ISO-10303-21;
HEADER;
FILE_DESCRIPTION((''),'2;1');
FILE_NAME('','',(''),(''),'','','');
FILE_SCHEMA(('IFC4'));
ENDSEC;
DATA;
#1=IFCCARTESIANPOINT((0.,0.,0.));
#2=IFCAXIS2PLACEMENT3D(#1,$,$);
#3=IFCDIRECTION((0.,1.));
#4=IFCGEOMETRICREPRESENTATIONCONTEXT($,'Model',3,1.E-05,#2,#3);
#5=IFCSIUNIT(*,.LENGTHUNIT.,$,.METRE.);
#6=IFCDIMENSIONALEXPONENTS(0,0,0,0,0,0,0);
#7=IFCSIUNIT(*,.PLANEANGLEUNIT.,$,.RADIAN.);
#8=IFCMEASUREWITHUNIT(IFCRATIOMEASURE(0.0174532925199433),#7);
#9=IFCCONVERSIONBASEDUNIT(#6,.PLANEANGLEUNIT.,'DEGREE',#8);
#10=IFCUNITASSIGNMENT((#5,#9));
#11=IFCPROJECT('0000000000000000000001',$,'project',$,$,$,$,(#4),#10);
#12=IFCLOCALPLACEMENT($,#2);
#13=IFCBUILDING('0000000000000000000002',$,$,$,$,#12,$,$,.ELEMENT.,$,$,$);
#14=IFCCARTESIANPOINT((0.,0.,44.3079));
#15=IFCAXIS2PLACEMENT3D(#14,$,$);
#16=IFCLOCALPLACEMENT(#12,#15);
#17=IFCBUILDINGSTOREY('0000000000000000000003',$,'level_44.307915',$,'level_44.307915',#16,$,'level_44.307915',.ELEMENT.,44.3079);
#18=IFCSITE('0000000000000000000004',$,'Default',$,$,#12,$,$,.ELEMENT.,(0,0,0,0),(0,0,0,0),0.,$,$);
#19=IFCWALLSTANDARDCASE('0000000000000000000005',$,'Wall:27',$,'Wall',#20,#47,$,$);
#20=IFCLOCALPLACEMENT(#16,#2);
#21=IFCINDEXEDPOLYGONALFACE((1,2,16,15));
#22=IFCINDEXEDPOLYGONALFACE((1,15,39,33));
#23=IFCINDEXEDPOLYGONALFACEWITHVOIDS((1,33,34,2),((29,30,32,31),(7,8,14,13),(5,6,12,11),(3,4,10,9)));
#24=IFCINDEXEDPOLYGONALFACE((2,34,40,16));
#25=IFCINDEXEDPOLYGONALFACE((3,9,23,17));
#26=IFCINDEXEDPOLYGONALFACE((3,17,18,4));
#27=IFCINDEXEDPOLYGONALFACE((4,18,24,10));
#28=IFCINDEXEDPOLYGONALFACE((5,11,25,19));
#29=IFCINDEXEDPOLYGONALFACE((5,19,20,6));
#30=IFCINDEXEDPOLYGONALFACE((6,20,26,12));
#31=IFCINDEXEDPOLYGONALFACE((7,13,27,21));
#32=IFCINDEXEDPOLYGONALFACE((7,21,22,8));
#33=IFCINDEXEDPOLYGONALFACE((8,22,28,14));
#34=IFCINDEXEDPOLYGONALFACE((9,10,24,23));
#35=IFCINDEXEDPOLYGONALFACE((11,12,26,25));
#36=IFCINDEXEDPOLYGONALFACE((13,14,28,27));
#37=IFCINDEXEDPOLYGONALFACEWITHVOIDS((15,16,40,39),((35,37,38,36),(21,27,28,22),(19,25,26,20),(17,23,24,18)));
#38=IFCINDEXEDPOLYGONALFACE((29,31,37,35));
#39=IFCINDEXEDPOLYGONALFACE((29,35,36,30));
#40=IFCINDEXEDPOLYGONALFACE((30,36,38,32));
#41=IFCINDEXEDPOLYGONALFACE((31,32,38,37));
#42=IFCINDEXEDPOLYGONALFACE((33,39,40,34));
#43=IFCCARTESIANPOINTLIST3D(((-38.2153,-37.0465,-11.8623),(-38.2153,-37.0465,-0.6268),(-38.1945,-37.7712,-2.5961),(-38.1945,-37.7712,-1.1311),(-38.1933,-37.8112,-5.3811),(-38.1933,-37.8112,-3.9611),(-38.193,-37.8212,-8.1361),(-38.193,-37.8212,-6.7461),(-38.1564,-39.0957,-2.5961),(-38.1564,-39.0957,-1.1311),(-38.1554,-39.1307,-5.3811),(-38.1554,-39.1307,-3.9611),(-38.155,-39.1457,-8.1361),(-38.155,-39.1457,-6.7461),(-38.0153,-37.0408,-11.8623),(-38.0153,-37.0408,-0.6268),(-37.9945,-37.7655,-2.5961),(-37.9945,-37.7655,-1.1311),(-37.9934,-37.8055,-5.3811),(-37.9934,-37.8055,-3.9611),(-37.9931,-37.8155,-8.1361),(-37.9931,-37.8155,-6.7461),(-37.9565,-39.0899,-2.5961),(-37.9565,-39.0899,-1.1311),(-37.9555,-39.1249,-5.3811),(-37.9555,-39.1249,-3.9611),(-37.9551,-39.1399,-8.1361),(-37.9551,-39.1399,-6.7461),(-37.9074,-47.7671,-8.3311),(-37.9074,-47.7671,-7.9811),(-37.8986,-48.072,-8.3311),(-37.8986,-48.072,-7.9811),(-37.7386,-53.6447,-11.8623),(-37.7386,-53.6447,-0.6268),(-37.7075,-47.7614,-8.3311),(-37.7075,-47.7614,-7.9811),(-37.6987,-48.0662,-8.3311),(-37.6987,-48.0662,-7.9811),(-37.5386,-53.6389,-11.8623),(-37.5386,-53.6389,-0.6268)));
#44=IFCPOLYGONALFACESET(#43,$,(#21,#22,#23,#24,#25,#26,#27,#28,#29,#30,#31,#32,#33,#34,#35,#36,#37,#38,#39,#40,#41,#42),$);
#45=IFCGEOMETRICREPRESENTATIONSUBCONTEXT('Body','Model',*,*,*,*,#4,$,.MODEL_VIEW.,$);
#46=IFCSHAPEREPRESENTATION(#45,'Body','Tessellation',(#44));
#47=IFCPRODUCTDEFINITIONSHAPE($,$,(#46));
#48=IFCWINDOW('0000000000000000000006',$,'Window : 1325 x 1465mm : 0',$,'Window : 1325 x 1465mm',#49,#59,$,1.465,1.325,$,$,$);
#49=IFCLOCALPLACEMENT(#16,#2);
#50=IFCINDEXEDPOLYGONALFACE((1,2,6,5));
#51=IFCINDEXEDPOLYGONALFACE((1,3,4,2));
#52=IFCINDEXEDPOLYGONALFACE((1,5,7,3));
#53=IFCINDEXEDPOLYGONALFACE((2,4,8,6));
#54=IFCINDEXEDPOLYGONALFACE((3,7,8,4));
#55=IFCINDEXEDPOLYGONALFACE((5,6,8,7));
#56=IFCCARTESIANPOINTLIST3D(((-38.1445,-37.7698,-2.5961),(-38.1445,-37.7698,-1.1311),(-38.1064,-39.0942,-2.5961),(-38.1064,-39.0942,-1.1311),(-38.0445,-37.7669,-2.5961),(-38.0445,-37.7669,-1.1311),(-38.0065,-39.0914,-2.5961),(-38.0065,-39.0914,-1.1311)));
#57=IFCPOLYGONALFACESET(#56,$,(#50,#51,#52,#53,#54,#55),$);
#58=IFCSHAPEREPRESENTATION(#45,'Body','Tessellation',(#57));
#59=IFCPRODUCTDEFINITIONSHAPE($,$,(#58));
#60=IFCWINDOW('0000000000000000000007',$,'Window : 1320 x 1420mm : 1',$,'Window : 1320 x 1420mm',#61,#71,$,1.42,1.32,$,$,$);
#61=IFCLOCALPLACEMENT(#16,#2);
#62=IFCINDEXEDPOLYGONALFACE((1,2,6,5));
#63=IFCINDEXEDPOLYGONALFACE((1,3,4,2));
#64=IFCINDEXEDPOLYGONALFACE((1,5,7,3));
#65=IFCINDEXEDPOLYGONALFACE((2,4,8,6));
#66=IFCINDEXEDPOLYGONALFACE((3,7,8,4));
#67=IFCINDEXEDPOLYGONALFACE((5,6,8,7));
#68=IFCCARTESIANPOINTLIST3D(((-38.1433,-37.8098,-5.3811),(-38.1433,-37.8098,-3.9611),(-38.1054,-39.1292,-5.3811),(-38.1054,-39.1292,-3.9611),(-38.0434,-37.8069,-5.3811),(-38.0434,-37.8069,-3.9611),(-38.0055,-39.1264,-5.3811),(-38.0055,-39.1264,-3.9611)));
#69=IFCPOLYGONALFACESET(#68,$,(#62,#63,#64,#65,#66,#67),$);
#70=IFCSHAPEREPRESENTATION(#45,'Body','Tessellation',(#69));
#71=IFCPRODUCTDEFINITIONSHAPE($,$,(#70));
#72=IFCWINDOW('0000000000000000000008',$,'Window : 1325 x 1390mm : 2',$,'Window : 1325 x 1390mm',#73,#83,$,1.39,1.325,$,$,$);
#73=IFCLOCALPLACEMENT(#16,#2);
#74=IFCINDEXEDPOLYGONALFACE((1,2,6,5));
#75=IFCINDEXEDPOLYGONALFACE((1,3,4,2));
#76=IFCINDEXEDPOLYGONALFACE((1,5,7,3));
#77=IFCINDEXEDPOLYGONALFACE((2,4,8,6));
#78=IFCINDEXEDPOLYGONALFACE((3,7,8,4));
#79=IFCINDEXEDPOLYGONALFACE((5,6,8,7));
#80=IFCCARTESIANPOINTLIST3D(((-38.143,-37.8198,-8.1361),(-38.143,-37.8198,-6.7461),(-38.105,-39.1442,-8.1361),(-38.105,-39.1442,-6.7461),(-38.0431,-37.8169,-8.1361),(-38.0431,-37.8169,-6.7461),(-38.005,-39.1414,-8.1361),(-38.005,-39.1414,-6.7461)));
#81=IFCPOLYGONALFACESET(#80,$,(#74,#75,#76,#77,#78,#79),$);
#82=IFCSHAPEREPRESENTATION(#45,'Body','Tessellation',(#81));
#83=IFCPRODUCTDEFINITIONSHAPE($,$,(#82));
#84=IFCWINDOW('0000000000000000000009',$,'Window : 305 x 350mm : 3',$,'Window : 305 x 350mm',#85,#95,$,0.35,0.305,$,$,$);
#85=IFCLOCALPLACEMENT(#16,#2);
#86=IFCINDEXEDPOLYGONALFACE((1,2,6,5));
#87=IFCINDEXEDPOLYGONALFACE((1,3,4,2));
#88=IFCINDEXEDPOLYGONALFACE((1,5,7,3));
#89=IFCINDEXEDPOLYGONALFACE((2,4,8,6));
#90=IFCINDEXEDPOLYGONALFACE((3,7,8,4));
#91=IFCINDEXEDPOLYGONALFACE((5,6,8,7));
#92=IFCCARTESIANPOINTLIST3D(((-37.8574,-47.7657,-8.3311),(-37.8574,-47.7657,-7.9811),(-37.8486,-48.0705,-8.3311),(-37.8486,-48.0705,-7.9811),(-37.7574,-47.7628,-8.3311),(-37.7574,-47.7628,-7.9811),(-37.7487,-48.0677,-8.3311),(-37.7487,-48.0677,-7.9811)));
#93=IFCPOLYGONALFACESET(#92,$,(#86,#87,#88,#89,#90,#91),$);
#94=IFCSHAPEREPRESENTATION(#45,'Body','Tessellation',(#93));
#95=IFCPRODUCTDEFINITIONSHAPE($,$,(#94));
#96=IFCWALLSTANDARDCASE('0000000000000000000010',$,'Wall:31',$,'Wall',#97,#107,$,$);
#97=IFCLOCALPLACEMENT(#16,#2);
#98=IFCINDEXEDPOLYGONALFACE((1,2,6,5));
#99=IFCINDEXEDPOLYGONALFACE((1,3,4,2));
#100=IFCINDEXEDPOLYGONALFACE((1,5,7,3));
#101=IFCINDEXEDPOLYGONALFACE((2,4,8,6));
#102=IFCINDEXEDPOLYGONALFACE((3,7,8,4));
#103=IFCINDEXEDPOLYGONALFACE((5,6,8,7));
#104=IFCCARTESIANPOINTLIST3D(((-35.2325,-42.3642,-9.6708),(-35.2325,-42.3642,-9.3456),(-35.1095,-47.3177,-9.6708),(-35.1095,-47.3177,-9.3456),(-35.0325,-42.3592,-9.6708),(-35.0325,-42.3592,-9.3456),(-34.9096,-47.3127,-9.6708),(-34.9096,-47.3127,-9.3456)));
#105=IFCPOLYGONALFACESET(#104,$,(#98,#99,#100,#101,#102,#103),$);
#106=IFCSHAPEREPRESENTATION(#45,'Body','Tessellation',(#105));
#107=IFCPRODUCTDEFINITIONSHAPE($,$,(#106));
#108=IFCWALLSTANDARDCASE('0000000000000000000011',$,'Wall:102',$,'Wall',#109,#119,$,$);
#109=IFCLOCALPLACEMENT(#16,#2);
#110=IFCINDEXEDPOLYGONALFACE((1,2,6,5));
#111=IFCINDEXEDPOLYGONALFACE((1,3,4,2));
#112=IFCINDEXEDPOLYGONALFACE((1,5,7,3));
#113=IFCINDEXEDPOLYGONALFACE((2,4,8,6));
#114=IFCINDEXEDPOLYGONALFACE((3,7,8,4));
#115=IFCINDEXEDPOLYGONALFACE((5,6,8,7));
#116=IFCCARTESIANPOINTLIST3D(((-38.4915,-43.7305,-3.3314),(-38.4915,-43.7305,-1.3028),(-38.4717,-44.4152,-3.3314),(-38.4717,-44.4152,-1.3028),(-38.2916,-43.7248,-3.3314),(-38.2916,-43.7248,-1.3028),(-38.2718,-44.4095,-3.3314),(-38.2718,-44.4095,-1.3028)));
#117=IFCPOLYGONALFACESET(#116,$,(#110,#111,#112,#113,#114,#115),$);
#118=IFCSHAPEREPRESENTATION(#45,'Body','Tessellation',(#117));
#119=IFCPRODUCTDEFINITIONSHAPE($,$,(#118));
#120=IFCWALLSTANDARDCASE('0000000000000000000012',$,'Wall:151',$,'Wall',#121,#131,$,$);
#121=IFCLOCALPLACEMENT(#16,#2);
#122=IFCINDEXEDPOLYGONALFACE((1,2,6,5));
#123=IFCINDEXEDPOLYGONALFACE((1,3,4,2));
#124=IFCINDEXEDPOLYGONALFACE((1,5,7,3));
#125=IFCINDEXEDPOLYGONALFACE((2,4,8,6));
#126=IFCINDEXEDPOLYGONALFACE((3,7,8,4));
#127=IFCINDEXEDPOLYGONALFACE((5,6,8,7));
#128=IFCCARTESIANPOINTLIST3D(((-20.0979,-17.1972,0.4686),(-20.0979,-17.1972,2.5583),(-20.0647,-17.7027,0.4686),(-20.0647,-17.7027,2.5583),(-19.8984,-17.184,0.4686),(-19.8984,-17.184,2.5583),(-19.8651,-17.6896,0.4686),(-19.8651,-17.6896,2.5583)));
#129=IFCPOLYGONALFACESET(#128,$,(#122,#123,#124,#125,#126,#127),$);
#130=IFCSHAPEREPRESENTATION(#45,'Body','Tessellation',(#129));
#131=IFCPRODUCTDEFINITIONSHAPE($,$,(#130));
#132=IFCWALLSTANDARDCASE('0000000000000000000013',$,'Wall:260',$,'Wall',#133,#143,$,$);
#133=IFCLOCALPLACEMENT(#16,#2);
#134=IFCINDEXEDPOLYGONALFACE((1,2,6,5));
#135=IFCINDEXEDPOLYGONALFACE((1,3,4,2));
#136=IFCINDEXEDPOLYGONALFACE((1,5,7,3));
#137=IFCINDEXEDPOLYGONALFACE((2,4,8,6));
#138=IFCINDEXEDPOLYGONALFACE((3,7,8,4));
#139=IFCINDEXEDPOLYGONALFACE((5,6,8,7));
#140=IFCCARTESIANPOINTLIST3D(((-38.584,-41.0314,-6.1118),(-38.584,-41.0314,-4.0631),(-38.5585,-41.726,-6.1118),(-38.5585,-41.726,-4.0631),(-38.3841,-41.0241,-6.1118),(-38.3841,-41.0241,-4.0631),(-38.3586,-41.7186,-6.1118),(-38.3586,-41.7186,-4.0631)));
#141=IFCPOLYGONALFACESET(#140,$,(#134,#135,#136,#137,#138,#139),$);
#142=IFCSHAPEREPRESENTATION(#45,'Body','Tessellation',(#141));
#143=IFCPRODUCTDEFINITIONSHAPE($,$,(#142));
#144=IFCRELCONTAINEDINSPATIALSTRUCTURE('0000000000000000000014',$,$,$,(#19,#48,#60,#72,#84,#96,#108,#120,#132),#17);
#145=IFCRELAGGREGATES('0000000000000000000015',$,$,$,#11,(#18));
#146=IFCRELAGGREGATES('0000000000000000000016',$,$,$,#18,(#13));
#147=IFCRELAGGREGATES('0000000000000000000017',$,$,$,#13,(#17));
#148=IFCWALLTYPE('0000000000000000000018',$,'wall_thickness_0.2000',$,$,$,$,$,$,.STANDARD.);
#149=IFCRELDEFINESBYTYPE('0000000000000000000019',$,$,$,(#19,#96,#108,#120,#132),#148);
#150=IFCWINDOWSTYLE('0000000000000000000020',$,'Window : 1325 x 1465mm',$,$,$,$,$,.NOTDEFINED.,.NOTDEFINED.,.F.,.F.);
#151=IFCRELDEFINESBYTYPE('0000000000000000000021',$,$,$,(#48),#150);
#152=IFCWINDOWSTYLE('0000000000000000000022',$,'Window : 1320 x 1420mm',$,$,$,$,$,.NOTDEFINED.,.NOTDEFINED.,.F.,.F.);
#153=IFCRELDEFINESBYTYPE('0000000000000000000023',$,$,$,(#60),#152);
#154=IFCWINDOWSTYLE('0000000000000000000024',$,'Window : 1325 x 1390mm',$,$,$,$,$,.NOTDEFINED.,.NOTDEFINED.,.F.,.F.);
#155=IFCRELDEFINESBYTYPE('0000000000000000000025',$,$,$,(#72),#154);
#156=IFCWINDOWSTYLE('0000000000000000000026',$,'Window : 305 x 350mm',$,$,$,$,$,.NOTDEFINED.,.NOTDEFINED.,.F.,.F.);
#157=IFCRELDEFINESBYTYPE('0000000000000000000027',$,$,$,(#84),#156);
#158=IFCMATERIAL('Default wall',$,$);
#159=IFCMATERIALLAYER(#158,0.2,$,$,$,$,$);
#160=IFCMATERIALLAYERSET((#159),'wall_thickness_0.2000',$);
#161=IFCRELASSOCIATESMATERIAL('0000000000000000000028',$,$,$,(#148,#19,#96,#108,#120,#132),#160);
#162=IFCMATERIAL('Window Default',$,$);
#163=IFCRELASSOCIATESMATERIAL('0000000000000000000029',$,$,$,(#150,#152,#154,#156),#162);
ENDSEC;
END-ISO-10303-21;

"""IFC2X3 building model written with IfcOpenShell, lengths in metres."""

from ifc_helpers import new_model, entity, si_unit, converted_unit, direction, frame, frame_2d, origin, origin_2d_with_axis, place, context, subcontext, project, spatial, polyline, rectangle, outline, extrude, source, transform, mapped, material, layer, layer_set, layer_usage, type_object, type_shapes, element, fill, save


model = new_model("IFC2X3")

# Units and contexts
model_context = context("Model", 3, precision=1e-05, world=origin(), true_north=direction((0.0, 1.0)))
body_context = subcontext(model_context, "Body", "Model", "MODEL_VIEW")
ifc_project = project(units=[si_unit("LENGTHUNIT", "METRE"), converted_unit("PLANEANGLEUNIT", "DEGREE", entity("IfcRatioMeasure", 0.0174532925199433), si_unit("PLANEANGLEUNIT", "RADIAN"), dimensions=[0, 0, 0, 0, 0, 0, 0])], contexts=[model_context])

# Site, building, storey
placement_1 = place(None, origin())
site = spatial("IfcSite", under=ifc_project, at=placement_1, Name="Default", CompositionType="ELEMENT", RefLatitude=(0, 0, 0, 0), RefLongitude=(0, 0, 0, 0), RefElevation=0.0)
building = spatial("IfcBuilding", under=site, at=placement_1, CompositionType="ELEMENT")
storey_placement = place(placement_1, frame((0.0, 0.0, 44.3079)))
storey = spatial("IfcBuildingStorey", under=building, at=storey_placement, Name="level_44.307915", ObjectType="level_44.307915", LongName="level_44.307915", CompositionType="ELEMENT", Elevation=44.3079)

# Wall, openings, windows
ifc_material_1 = material(Name="Default wall")
ifc_layer = layer(ifc_material_1, 0.2)
ifc_layer_set = layer_set([ifc_layer], Name="wall_thickness_0.2000")
ifc_layer_usage = layer_usage(ifc_layer_set, "AXIS2", "POSITIVE", -0.1)
wall_type = type_object("IfcWallType", Name="wall_thickness_0.2000", PredefinedType="STANDARD", material=ifc_layer_set)
placement_2 = place(placement_1, frame((0.0, 0.0, 32.4456)))
wall_1_placement = place(placement_2, frame((-37.6386, -53.6418, 0.0), z_axis=(0.0, 0.0, 1.0), x_axis=(-0.028708, 0.999588, 0.0)))
wall_1 = element("IfcWallStandardCase", 1, at=wall_1_placement, inside=storey, type_object=wall_type, material=ifc_layer_usage, Name="Wall:27", ObjectType="Wall", context=body_context, shape_type="SweptSolid", body=[
    extrude(outline(polyline([(16.605, -0.1), (16.605, 0.1), (0.0, 0.1), (0.0, -0.1), (16.605, -0.1)])), origin(), (0.0, 0.0, 1.0), 11.2356),
])
opening_1_placement = place(wall_1_placement, frame((14.555, -0.1, 9.2662)))
opening_1 = element("IfcOpeningElement", 2, at=opening_1_placement, cuts=wall_1, ObjectType="Opening", context=body_context, shape_type="SweptSolid", body=[
    extrude(rectangle(XDim=1.325, YDim=1.465, at=frame_2d((0.7325, 0.6625), x_axis=(0.0, 1.0))), frame((0.0, 0.0, 0.0), z_axis=(0.0, 1.0, 0.0), x_axis=(0.0, 0.0, 1.0)), (0.0, 0.0, 1.0), 0.2),
])
opening_2_placement = place(wall_1_placement, frame((14.52, -0.1, 6.4812)))
opening_2 = element("IfcOpeningElement", 3, at=opening_2_placement, cuts=wall_1, ObjectType="Opening", context=body_context, shape_type="SweptSolid", body=[
    extrude(rectangle(XDim=1.32, YDim=1.42, at=frame_2d((0.71, 0.66), x_axis=(0.0, 1.0))), frame((0.0, 0.0, 0.0), z_axis=(0.0, 1.0, 0.0), x_axis=(0.0, 0.0, 1.0)), (0.0, 0.0, 1.0), 0.2),
])
opening_3_placement = place(wall_1_placement, frame((14.505, -0.1, 3.7262)))
opening_3 = element("IfcOpeningElement", 4, at=opening_3_placement, cuts=wall_1, ObjectType="Opening", context=body_context, shape_type="SweptSolid", body=[
    extrude(rectangle(XDim=1.325, YDim=1.39, at=frame_2d((0.695, 0.6625), x_axis=(0.0, 1.0))), frame((0.0, 0.0, 0.0), z_axis=(0.0, 1.0, 0.0), x_axis=(0.0, 0.0, 1.0)), (0.0, 0.0, 1.0), 0.2),
])
opening_4_placement = place(wall_1_placement, frame((5.575, -0.1, 3.5312)))
opening_4 = element("IfcOpeningElement", 5, at=opening_4_placement, cuts=wall_1, ObjectType="Opening", context=body_context, shape_type="SweptSolid", body=[
    extrude(rectangle(XDim=0.305, YDim=0.35, at=frame_2d((0.175, 0.1525), x_axis=(0.0, 1.0))), frame((0.0, 0.0, 0.0), z_axis=(0.0, 1.0, 0.0), x_axis=(0.0, 0.0, 1.0)), (0.0, 0.0, 1.0), 0.2),
])
ifc_material_2 = material(Name="Window Default")
window_style_1 = type_object("IfcWindowStyle", Name="Window : 1325 x 1465mm", ConstructionType="NOTDEFINED", OperationType="NOTDEFINED", ParameterTakesPrecedence=False, Sizeable=False, material=ifc_material_2)
shared_shape_1 = source(origin(), body_context, "Body", "SweptSolid", [
    extrude(rectangle(XDim=0.1, YDim=1.325, at=origin_2d_with_axis()), frame((0.6625, 0.1, 0.0), z_axis=(0.0, 0.0, 1.0), x_axis=(0.0, 1.0, 0.0)), (0.0, 0.0, 1.0), 1.465),
])
type_shapes(window_style_1, [shared_shape_1])
window_1_placement = place(opening_1_placement, origin())
window_1 = element("IfcWindow", 6, at=window_1_placement, inside=storey, type_object=window_style_1, Name="Window : 1325 x 1465mm : 0", ObjectType="Window : 1325 x 1465mm", OverallHeight=1.465, OverallWidth=1.325, context=body_context, shape_type="MappedRepresentation", body=[
    mapped(shared_shape_1, transform((0.0, 0.0, 0.0), scale=1.0)),
])
fill(opening_1, window_1)
window_style_2 = type_object("IfcWindowStyle", Name="Window : 1320 x 1420mm", ConstructionType="NOTDEFINED", OperationType="NOTDEFINED", ParameterTakesPrecedence=False, Sizeable=False, material=ifc_material_2)
shared_shape_2 = source(origin(), body_context, "Body", "SweptSolid", [
    extrude(rectangle(XDim=0.1, YDim=1.32, at=origin_2d_with_axis()), frame((0.66, 0.1, 0.0), z_axis=(0.0, 0.0, 1.0), x_axis=(0.0, 1.0, 0.0)), (0.0, 0.0, 1.0), 1.42),
])
type_shapes(window_style_2, [shared_shape_2])
window_2_placement = place(opening_2_placement, origin())
window_2 = element("IfcWindow", 7, at=window_2_placement, inside=storey, type_object=window_style_2, Name="Window : 1320 x 1420mm : 1", ObjectType="Window : 1320 x 1420mm", OverallHeight=1.42, OverallWidth=1.32, context=body_context, shape_type="MappedRepresentation", body=[
    mapped(shared_shape_2, transform((0.0, 0.0, 0.0), scale=1.0)),
])
fill(opening_2, window_2)
window_style_3 = type_object("IfcWindowStyle", Name="Window : 1325 x 1390mm", ConstructionType="NOTDEFINED", OperationType="NOTDEFINED", ParameterTakesPrecedence=False, Sizeable=False, material=ifc_material_2)
shared_shape_3 = source(origin(), body_context, "Body", "SweptSolid", [
    extrude(rectangle(XDim=0.1, YDim=1.325, at=origin_2d_with_axis()), frame((0.6625, 0.1, 0.0), z_axis=(0.0, 0.0, 1.0), x_axis=(0.0, 1.0, 0.0)), (0.0, 0.0, 1.0), 1.39),
])
type_shapes(window_style_3, [shared_shape_3])
window_3_placement = place(opening_3_placement, origin())
window_3 = element("IfcWindow", 8, at=window_3_placement, inside=storey, type_object=window_style_3, Name="Window : 1325 x 1390mm : 2", ObjectType="Window : 1325 x 1390mm", OverallHeight=1.39, OverallWidth=1.325, context=body_context, shape_type="MappedRepresentation", body=[
    mapped(shared_shape_3, transform((0.0, 0.0, 0.0), scale=1.0)),
])
fill(opening_3, window_3)
window_style_4 = type_object("IfcWindowStyle", Name="Window : 305 x 350mm", ConstructionType="NOTDEFINED", OperationType="NOTDEFINED", ParameterTakesPrecedence=False, Sizeable=False, material=ifc_material_2)
shared_shape_4 = source(origin(), body_context, "Body", "SweptSolid", [
    extrude(rectangle(XDim=0.1, YDim=0.305, at=origin_2d_with_axis()), frame((0.1525, 0.1, 0.0), z_axis=(0.0, 0.0, 1.0), x_axis=(0.0, 1.0, 0.0)), (0.0, 0.0, 1.0), 0.35),
])
type_shapes(window_style_4, [shared_shape_4])
window_4_placement = place(opening_4_placement, origin())
window_4 = element("IfcWindow", 9, at=window_4_placement, inside=storey, type_object=window_style_4, Name="Window : 305 x 350mm : 3", ObjectType="Window : 305 x 350mm", OverallHeight=0.35, OverallWidth=0.305, context=body_context, shape_type="MappedRepresentation", body=[
    mapped(shared_shape_4, transform((0.0, 0.0, 0.0), scale=1.0)),
])
fill(opening_4, window_4)

# Walls
placement_3 = place(placement_1, frame((0.0, 0.0, 34.6371)))
wall_2_placement = place(placement_3, frame((-35.1325, -42.3617, 0.0), z_axis=(0.0, 0.0, 1.0), x_axis=(0.024812, -0.999692, 0.0)))
element("IfcWallStandardCase", 10, at=wall_2_placement, inside=storey, type_object=wall_type, material=ifc_layer_usage, Name="Wall:31", ObjectType="Wall", context=body_context, shape_type="SweptSolid", body=[
    extrude(outline(polyline([(4.955, -0.1), (4.955, 0.1), (0.0, 0.1), (0.0, -0.1), (4.955, -0.1)])), origin(), (0.0, 0.0, 1.0), 0.3252),
])
placement_4 = place(placement_1, frame((0.0, 0.0, 40.9765)))
wall_3_placement = place(placement_4, frame((-38.3718, -44.4124, 0.0), z_axis=(0.0, 0.0, 1.0), x_axis=(-0.028836, 0.999584, 0.0)))
element("IfcWallStandardCase", 11, at=wall_3_placement, inside=storey, type_object=wall_type, material=ifc_layer_usage, Name="Wall:102", ObjectType="Wall", context=body_context, shape_type="SweptSolid", body=[
    extrude(outline(polyline([(0.685, -0.1), (0.685, 0.1), (0.0, 0.1), (0.0, -0.1), (0.685, -0.1)])), origin(), (0.0, 0.0, 1.0), 2.0286),
])
placement_5 = place(placement_1, frame((0.0, 0.0, 44.7765)))
wall_4_placement = place(placement_5, frame((-19.9981, -17.1906, 0.0), z_axis=(0.0, 0.0, 1.0), x_axis=(0.065622, -0.997845, 0.0)))
element("IfcWallStandardCase", 12, at=wall_4_placement, inside=storey, type_object=wall_type, material=ifc_layer_usage, Name="Wall:151", ObjectType="Wall", context=body_context, shape_type="SweptSolid", body=[
    extrude(outline(polyline([(0.5066, -0.1), (0.5066, 0.1), (0.0, 0.1), (0.0, -0.1), (0.5066, -0.1)])), origin(), (0.0, 0.0, 1.0), 2.0897),
])
placement_6 = place(placement_1, frame((0.0, 0.0, 38.1961)))
wall_5_placement = place(placement_6, frame((-38.4841, -41.0278, 0.0), z_axis=(0.0, 0.0, 1.0), x_axis=(0.036676, -0.999327, 0.0)))
element("IfcWallStandardCase", 13, at=wall_5_placement, inside=storey, type_object=wall_type, material=ifc_layer_usage, Name="Wall:260", ObjectType="Wall", context=body_context, shape_type="SweptSolid", body=[
    extrude(outline(polyline([(0.695, -0.1), (0.695, 0.1), (0.0, 0.1), (0.0, -0.1), (0.695, -0.1)])), origin(), (0.0, 0.0, 1.0), 2.0487),
])

save(model, "model.ifc")
